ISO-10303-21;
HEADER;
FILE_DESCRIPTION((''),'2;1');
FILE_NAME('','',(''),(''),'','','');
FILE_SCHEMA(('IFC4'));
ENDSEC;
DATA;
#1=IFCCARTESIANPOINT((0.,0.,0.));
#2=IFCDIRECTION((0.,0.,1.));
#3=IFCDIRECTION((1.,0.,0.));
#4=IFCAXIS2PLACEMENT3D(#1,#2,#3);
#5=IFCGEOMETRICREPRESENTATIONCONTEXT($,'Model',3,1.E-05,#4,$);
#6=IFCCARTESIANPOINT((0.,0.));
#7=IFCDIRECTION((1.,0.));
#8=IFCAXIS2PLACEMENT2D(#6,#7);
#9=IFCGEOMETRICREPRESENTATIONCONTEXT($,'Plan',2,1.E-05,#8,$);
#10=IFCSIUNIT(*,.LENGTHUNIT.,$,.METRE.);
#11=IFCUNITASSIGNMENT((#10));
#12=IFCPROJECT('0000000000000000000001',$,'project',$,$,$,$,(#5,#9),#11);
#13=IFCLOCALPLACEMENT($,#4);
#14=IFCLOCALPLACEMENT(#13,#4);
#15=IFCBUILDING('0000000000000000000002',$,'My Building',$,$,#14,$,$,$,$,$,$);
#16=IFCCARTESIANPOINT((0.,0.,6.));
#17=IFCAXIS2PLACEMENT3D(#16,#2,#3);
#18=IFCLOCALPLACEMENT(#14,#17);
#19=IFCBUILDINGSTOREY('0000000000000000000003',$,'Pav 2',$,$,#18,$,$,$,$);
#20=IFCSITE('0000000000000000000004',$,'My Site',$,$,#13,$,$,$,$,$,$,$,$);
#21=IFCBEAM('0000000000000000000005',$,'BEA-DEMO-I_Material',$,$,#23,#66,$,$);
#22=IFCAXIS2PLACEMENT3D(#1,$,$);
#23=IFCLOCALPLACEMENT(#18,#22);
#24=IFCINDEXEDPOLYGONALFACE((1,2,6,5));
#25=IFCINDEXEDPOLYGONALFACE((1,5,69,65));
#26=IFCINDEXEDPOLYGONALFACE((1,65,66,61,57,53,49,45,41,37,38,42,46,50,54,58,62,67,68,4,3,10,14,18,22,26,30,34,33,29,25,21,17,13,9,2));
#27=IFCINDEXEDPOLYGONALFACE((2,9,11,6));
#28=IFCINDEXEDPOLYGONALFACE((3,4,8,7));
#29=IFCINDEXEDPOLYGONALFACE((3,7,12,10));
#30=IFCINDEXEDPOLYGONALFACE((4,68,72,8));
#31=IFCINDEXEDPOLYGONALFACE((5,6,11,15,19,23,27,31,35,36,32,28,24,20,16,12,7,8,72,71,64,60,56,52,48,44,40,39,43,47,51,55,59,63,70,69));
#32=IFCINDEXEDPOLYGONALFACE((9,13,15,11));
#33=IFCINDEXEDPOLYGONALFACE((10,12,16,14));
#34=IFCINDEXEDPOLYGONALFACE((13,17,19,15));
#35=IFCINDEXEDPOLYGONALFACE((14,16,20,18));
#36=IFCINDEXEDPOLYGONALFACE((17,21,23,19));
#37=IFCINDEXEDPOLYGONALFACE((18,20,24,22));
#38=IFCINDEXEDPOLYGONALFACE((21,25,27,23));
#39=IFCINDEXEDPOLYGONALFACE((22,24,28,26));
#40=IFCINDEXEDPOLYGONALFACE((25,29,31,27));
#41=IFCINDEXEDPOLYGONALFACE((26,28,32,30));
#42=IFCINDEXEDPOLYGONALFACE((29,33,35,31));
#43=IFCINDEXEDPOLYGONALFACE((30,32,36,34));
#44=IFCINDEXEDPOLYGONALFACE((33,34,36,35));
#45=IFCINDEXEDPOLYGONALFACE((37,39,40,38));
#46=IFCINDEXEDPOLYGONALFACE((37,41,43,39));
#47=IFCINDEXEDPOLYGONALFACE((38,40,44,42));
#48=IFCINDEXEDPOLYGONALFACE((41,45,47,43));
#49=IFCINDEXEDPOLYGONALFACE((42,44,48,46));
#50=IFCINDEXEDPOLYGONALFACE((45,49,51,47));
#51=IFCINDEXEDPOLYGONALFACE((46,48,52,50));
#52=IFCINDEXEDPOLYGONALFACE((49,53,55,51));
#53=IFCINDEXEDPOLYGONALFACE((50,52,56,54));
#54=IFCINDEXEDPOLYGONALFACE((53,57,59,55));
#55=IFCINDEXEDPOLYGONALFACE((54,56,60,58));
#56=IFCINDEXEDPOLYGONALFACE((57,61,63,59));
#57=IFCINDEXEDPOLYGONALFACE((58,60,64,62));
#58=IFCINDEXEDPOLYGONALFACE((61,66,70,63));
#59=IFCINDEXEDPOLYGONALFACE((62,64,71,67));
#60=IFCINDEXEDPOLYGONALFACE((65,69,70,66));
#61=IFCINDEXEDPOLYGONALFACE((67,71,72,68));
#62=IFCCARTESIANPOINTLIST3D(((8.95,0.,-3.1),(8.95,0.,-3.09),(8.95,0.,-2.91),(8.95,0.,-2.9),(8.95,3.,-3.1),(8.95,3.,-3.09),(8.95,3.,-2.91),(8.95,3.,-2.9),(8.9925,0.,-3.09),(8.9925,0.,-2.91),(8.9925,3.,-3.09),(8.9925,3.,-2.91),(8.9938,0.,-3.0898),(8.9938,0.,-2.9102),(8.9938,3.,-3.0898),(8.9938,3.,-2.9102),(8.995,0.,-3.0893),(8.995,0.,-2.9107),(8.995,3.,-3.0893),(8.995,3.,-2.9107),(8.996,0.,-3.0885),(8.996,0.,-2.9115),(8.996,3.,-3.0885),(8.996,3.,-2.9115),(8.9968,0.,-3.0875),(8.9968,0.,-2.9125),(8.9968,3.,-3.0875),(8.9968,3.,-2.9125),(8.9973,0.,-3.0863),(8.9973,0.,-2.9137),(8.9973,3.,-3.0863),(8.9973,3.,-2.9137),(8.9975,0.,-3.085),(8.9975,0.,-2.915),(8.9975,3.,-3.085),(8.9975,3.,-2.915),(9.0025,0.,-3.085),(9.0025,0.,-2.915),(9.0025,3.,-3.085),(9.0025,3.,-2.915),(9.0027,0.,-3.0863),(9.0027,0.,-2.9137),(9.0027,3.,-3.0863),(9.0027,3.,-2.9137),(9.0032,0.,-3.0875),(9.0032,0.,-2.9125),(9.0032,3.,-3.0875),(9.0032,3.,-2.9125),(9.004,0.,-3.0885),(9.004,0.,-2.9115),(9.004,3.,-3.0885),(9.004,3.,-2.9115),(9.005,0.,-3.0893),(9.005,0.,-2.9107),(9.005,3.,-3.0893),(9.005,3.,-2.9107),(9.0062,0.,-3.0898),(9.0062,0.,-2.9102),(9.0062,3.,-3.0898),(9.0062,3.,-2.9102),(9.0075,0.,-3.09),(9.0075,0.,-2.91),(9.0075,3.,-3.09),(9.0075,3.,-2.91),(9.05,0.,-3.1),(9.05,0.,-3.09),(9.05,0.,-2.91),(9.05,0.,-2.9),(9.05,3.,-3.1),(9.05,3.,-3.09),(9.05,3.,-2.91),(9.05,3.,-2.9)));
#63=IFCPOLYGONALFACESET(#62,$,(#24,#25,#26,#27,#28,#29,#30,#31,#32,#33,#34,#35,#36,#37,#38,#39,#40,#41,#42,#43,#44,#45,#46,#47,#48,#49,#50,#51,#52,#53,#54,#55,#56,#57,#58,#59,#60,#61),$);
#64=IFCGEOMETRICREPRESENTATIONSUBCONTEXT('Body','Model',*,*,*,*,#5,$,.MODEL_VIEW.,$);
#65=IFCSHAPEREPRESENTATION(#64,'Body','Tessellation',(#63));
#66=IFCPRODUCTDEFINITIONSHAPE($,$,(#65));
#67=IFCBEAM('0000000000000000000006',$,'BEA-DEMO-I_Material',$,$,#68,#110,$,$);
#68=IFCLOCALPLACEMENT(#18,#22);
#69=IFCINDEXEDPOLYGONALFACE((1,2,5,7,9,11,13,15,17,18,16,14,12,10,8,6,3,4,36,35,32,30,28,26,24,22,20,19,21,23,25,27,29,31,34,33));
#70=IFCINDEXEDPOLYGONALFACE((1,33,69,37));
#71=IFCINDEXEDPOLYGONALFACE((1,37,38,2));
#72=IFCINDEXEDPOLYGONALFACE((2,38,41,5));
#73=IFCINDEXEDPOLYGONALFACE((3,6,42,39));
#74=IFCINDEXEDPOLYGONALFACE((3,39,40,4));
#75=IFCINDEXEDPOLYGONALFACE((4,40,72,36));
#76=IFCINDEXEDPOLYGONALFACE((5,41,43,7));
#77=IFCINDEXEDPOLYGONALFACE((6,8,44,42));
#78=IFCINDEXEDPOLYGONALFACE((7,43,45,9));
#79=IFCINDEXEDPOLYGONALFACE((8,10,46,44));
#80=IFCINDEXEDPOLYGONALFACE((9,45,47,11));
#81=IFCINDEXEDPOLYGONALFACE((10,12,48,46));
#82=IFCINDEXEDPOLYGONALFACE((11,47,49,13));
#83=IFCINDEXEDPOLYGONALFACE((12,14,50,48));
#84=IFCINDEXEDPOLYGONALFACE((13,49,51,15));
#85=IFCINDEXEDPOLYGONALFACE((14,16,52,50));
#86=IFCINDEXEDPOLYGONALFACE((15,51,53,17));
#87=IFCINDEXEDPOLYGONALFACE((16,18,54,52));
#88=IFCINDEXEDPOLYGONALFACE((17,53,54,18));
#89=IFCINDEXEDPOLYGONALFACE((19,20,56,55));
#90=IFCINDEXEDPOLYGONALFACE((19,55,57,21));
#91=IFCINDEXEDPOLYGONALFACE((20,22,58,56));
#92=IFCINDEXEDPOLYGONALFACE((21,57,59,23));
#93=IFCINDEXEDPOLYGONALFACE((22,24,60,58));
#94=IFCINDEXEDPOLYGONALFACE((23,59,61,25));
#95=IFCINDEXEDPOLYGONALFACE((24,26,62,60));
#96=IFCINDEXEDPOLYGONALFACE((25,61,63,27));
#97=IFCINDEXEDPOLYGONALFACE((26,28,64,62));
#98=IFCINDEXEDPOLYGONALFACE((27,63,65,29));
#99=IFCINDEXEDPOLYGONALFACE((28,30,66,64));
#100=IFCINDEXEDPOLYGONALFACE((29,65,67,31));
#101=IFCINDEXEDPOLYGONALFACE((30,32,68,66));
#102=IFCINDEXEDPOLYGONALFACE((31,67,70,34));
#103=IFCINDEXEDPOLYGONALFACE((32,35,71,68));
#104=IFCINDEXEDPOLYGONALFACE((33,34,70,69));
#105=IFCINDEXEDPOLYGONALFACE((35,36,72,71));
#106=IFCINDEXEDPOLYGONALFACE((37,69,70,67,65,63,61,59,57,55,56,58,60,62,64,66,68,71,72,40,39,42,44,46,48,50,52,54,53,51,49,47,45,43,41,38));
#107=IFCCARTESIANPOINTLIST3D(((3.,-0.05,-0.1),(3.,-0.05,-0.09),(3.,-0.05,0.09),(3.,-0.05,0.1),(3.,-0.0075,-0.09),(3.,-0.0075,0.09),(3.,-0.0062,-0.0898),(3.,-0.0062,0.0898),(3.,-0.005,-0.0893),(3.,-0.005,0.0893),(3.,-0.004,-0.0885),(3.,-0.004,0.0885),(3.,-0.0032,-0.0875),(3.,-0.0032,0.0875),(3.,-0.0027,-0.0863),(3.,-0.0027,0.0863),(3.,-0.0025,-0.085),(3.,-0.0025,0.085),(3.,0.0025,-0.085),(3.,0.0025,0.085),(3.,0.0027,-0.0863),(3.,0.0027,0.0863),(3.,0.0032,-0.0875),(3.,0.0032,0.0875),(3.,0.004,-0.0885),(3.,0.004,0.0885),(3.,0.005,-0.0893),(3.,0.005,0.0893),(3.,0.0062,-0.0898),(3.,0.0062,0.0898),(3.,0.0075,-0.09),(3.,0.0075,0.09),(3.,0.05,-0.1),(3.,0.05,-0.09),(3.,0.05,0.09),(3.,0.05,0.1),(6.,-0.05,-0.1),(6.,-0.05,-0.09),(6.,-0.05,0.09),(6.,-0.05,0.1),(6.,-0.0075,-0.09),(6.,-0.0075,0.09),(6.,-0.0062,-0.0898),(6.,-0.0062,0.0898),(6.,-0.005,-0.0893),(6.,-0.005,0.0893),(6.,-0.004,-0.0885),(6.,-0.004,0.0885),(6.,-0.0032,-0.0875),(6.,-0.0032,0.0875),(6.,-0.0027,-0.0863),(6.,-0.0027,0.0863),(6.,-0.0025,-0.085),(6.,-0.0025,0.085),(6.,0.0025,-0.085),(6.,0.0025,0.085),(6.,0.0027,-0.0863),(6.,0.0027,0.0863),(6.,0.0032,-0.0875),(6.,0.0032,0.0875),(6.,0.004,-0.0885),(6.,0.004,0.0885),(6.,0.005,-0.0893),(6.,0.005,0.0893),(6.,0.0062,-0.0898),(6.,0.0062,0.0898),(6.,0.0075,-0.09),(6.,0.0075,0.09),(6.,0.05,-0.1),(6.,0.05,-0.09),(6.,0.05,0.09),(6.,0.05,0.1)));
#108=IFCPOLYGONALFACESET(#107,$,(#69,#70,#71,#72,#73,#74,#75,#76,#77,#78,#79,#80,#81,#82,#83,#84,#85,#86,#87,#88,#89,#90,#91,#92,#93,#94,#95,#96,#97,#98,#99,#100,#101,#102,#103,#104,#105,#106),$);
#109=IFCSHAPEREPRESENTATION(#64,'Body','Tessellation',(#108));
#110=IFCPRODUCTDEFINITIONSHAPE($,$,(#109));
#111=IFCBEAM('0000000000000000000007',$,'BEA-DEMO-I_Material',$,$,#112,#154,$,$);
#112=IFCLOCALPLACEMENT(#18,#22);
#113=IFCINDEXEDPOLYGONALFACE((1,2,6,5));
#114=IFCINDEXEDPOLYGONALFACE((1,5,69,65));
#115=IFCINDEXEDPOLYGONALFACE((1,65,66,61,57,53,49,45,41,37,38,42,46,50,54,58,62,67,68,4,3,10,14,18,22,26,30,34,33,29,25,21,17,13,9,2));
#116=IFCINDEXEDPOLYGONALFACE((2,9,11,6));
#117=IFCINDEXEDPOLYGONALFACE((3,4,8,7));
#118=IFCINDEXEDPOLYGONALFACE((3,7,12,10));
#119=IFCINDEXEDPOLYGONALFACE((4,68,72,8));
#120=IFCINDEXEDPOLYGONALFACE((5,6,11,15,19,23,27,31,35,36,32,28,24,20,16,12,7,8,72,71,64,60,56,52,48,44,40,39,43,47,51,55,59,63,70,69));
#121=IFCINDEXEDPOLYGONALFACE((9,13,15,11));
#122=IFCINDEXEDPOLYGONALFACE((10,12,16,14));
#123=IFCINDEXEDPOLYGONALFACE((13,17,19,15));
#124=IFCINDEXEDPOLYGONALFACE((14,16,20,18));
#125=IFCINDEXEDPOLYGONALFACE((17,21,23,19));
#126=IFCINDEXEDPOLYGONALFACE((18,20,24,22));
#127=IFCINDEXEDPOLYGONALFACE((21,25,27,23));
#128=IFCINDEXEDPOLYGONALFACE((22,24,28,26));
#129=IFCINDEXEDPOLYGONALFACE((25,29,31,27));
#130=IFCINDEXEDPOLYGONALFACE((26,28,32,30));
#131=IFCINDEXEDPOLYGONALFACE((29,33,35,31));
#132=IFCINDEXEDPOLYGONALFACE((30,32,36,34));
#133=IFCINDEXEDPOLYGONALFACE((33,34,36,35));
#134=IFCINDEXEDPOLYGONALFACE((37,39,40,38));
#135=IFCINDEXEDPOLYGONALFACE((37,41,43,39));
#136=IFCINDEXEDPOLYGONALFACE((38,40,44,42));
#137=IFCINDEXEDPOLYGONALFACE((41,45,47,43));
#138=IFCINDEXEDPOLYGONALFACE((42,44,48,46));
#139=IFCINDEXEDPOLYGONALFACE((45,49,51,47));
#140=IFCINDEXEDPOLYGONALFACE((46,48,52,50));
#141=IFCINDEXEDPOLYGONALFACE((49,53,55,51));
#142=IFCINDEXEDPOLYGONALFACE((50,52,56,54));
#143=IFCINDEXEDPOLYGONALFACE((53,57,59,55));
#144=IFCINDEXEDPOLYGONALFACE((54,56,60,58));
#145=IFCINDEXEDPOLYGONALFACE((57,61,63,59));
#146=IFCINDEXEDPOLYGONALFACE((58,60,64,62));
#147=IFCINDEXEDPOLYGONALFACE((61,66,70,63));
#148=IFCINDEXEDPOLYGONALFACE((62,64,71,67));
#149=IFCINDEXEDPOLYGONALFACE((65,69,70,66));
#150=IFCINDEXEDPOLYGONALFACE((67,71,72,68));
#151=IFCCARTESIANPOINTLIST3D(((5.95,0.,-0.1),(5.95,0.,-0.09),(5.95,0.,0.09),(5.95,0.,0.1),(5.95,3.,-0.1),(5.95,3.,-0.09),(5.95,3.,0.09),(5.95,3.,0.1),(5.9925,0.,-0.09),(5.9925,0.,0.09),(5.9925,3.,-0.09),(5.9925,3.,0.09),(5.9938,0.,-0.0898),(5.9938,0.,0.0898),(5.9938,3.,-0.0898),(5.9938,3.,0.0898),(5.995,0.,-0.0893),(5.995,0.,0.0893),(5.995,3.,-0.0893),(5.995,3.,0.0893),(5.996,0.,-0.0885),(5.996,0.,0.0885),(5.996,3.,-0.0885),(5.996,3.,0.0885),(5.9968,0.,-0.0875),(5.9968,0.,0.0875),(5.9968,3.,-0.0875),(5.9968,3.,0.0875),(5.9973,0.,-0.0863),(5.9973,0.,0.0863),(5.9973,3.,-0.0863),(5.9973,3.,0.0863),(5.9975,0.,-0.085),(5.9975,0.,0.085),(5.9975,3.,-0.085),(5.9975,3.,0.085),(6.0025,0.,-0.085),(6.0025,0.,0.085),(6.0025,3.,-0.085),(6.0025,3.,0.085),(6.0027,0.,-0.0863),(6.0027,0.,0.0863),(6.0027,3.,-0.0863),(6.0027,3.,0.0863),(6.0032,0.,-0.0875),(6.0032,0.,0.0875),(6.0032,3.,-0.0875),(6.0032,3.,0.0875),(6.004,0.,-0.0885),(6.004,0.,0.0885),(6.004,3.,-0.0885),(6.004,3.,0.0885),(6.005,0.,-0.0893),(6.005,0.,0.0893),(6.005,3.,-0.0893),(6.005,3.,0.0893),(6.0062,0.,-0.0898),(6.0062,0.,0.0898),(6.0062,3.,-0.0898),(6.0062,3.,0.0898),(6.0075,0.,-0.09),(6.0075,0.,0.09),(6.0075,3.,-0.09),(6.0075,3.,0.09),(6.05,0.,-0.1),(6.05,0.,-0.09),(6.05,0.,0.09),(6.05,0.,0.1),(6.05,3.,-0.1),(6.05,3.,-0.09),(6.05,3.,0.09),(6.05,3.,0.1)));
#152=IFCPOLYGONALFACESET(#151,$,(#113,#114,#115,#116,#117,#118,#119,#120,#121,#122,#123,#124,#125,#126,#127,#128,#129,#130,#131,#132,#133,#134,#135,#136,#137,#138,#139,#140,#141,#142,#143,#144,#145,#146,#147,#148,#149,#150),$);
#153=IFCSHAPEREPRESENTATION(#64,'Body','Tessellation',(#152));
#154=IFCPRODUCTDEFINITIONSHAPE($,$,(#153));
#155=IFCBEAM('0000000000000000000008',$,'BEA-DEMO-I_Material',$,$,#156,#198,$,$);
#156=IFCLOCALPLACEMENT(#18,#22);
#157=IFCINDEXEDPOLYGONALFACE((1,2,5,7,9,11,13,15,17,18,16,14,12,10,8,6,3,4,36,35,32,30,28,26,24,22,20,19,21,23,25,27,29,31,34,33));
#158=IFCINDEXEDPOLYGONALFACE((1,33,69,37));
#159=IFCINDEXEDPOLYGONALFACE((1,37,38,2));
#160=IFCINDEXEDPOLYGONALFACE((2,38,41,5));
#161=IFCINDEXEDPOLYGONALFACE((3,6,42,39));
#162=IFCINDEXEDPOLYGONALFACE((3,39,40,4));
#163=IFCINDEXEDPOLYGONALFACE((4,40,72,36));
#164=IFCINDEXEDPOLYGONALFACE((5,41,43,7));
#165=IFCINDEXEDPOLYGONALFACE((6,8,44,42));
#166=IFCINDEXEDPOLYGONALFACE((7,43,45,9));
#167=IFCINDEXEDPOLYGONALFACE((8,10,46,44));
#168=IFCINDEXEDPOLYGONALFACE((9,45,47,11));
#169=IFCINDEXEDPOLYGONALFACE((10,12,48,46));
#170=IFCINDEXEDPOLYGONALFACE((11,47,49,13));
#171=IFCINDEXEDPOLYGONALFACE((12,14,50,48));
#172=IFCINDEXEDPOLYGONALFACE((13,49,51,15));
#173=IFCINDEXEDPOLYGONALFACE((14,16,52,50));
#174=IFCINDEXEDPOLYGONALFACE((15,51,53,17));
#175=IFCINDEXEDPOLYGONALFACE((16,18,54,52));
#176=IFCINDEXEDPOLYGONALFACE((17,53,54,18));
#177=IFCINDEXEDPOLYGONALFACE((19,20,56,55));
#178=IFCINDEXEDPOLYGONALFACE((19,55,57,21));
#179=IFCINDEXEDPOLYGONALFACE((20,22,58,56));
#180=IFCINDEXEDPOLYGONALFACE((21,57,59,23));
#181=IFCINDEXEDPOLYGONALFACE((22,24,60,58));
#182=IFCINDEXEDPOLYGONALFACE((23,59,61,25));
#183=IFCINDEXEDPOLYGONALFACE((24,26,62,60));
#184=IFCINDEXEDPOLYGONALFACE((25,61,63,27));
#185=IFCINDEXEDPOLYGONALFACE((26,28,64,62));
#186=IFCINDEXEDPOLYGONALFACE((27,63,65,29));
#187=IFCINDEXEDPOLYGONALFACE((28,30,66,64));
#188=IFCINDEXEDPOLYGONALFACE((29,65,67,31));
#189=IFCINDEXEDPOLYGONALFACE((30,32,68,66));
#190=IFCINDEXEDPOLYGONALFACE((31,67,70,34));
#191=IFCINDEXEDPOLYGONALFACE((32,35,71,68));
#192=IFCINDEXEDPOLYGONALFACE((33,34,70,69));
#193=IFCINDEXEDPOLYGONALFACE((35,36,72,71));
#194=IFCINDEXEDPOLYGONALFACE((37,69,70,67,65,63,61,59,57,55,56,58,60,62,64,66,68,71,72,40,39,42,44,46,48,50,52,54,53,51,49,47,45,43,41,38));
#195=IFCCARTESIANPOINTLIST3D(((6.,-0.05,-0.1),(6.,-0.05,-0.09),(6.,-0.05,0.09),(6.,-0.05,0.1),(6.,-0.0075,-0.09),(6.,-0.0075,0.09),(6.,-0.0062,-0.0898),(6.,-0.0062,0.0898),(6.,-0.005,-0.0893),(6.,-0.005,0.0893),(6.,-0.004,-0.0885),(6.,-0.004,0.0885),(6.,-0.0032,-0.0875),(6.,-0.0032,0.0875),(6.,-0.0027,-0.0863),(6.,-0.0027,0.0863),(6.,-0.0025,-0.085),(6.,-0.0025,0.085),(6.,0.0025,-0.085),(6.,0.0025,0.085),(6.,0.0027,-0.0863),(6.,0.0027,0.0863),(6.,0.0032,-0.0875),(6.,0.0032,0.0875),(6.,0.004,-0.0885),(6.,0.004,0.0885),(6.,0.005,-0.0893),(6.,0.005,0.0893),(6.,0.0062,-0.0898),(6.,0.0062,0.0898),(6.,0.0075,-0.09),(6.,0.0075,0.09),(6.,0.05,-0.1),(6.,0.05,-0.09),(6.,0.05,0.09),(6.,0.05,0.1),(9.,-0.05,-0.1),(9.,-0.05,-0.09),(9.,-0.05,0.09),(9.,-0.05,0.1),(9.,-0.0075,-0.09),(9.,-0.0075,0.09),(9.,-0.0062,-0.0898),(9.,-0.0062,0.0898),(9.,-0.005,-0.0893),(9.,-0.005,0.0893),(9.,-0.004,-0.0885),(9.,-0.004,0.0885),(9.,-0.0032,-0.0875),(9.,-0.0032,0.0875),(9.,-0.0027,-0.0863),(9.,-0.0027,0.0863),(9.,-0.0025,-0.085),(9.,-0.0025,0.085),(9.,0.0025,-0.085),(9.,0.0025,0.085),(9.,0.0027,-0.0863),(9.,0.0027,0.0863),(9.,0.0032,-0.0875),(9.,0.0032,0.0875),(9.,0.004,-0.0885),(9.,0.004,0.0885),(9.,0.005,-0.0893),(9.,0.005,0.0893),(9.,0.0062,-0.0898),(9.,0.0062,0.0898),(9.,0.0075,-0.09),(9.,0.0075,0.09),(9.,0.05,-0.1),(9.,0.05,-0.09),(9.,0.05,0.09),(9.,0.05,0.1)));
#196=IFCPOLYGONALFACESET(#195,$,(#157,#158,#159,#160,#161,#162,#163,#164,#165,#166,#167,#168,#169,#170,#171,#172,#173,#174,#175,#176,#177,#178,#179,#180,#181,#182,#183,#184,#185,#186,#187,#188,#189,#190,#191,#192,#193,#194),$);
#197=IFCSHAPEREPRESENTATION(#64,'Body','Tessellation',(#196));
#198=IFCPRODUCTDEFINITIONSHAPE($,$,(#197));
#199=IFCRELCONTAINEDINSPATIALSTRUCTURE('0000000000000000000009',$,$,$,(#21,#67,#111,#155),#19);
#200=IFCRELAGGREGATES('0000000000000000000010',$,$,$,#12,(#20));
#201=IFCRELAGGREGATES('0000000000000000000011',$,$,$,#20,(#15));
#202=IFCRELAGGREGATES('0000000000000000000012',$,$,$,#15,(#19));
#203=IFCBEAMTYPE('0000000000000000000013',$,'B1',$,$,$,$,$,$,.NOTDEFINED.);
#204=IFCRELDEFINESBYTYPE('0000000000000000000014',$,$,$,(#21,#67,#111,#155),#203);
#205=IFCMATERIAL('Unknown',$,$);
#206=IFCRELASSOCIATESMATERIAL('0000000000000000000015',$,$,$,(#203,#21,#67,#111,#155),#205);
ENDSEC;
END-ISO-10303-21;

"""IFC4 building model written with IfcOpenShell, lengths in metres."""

from ifc_helpers import new_model, si_unit, frame, origin, origin_with_axes, origin_2d_with_axis, place, context, subcontext, project, spatial, i_section, extrude, material, material_profile, profile_set, profile_usage, type_object, element, save


model = new_model("IFC4")

# Units and contexts
model_context = context("Model", 3, precision=1e-05, world=origin_with_axes())
plan_context = context("Plan", 2, precision=1e-05, world=origin_2d_with_axis())
body_context = subcontext(model_context, "Body", "Model", "MODEL_VIEW")
ifc_project = project(units=[si_unit("LENGTHUNIT", "METRE")], contexts=[model_context, plan_context])

# Site, building, storey
site_placement = place(None, origin_with_axes())
site = spatial("IfcSite", under=ifc_project, at=site_placement, Name="My Site")
building_placement = place(site_placement, origin_with_axes())
building = spatial("IfcBuilding", under=site, at=building_placement, Name="My Building")
storey_placement = place(building_placement, frame((0.0, 0.0, 6.0), z_axis=(0.0, 0.0, 1.0), x_axis=(1.0, 0.0, 0.0)))
storey = spatial("IfcBuildingStorey", under=building, at=storey_placement, Name="Pav 2")

# Beams
ifc_material = material(Name="Unknown")
ifc_material_profile = material_profile(ifc_material, i_section(OverallWidth=0.1, OverallDepth=0.2, WebThickness=0.005, FlangeThickness=0.01, FilletRadius=0.005))
ifc_profile_set = profile_set([ifc_material_profile])
beam_type = type_object("IfcBeamType", Name="B1", PredefinedType="NOTDEFINED", material=ifc_profile_set)
ifc_profile_usage_1 = profile_usage(ifc_profile_set, cardinal=5)
beam_1_placement = place(storey_placement, frame((9.0, 3.0, -3.0), z_axis=(0.0, -1.0, 0.0), x_axis=(1.0, 0.0, 0.0)))
element("IfcBeam", 1, at=beam_1_placement, inside=storey, type_object=beam_type, material=ifc_profile_usage_1, Name="BEA-DEMO-I_Material", context=body_context, shape_type="SweptSolid", body=[
    extrude(i_section(OverallWidth=0.1, OverallDepth=0.2, WebThickness=0.005, FlangeThickness=0.01, FilletRadius=0.005), origin(), (0.0, 0.0, 1.0), 3.0),
])
ifc_profile_usage_2 = profile_usage(ifc_profile_set, cardinal=5)
beam_2_placement = place(storey_placement, frame((6.0, 0.0, 0.0), z_axis=(-1.0, 0.0, 0.0), x_axis=(0.0, -1.0, 0.0)))
element("IfcBeam", 2, at=beam_2_placement, inside=storey, type_object=beam_type, material=ifc_profile_usage_2, Name="BEA-DEMO-I_Material", context=body_context, shape_type="SweptSolid", body=[
    extrude(i_section(OverallWidth=0.1, OverallDepth=0.2, WebThickness=0.005, FlangeThickness=0.01, FilletRadius=0.005), origin(), (0.0, 0.0, 1.0), 3.0),
])
ifc_profile_usage_3 = profile_usage(ifc_profile_set, cardinal=5)
beam_3_placement = place(storey_placement, frame((6.0, 3.0, 0.0), z_axis=(0.0, -1.0, 0.0), x_axis=(1.0, 0.0, 0.0)))
element("IfcBeam", 3, at=beam_3_placement, inside=storey, type_object=beam_type, material=ifc_profile_usage_3, Name="BEA-DEMO-I_Material", context=body_context, shape_type="SweptSolid", body=[
    extrude(i_section(OverallWidth=0.1, OverallDepth=0.2, WebThickness=0.005, FlangeThickness=0.01, FilletRadius=0.005), origin(), (0.0, 0.0, 1.0), 3.0),
])
ifc_profile_usage_4 = profile_usage(ifc_profile_set, cardinal=5)
beam_4_placement = place(storey_placement, frame((9.0, 0.0, 0.0), z_axis=(-1.0, 0.0, 0.0), x_axis=(0.0, -1.0, 0.0)))
element("IfcBeam", 4, at=beam_4_placement, inside=storey, type_object=beam_type, material=ifc_profile_usage_4, Name="BEA-DEMO-I_Material", context=body_context, shape_type="SweptSolid", body=[
    extrude(i_section(OverallWidth=0.1, OverallDepth=0.2, WebThickness=0.005, FlangeThickness=0.01, FilletRadius=0.005), origin(), (0.0, 0.0, 1.0), 3.0),
])

save(model, "model.ifc")
